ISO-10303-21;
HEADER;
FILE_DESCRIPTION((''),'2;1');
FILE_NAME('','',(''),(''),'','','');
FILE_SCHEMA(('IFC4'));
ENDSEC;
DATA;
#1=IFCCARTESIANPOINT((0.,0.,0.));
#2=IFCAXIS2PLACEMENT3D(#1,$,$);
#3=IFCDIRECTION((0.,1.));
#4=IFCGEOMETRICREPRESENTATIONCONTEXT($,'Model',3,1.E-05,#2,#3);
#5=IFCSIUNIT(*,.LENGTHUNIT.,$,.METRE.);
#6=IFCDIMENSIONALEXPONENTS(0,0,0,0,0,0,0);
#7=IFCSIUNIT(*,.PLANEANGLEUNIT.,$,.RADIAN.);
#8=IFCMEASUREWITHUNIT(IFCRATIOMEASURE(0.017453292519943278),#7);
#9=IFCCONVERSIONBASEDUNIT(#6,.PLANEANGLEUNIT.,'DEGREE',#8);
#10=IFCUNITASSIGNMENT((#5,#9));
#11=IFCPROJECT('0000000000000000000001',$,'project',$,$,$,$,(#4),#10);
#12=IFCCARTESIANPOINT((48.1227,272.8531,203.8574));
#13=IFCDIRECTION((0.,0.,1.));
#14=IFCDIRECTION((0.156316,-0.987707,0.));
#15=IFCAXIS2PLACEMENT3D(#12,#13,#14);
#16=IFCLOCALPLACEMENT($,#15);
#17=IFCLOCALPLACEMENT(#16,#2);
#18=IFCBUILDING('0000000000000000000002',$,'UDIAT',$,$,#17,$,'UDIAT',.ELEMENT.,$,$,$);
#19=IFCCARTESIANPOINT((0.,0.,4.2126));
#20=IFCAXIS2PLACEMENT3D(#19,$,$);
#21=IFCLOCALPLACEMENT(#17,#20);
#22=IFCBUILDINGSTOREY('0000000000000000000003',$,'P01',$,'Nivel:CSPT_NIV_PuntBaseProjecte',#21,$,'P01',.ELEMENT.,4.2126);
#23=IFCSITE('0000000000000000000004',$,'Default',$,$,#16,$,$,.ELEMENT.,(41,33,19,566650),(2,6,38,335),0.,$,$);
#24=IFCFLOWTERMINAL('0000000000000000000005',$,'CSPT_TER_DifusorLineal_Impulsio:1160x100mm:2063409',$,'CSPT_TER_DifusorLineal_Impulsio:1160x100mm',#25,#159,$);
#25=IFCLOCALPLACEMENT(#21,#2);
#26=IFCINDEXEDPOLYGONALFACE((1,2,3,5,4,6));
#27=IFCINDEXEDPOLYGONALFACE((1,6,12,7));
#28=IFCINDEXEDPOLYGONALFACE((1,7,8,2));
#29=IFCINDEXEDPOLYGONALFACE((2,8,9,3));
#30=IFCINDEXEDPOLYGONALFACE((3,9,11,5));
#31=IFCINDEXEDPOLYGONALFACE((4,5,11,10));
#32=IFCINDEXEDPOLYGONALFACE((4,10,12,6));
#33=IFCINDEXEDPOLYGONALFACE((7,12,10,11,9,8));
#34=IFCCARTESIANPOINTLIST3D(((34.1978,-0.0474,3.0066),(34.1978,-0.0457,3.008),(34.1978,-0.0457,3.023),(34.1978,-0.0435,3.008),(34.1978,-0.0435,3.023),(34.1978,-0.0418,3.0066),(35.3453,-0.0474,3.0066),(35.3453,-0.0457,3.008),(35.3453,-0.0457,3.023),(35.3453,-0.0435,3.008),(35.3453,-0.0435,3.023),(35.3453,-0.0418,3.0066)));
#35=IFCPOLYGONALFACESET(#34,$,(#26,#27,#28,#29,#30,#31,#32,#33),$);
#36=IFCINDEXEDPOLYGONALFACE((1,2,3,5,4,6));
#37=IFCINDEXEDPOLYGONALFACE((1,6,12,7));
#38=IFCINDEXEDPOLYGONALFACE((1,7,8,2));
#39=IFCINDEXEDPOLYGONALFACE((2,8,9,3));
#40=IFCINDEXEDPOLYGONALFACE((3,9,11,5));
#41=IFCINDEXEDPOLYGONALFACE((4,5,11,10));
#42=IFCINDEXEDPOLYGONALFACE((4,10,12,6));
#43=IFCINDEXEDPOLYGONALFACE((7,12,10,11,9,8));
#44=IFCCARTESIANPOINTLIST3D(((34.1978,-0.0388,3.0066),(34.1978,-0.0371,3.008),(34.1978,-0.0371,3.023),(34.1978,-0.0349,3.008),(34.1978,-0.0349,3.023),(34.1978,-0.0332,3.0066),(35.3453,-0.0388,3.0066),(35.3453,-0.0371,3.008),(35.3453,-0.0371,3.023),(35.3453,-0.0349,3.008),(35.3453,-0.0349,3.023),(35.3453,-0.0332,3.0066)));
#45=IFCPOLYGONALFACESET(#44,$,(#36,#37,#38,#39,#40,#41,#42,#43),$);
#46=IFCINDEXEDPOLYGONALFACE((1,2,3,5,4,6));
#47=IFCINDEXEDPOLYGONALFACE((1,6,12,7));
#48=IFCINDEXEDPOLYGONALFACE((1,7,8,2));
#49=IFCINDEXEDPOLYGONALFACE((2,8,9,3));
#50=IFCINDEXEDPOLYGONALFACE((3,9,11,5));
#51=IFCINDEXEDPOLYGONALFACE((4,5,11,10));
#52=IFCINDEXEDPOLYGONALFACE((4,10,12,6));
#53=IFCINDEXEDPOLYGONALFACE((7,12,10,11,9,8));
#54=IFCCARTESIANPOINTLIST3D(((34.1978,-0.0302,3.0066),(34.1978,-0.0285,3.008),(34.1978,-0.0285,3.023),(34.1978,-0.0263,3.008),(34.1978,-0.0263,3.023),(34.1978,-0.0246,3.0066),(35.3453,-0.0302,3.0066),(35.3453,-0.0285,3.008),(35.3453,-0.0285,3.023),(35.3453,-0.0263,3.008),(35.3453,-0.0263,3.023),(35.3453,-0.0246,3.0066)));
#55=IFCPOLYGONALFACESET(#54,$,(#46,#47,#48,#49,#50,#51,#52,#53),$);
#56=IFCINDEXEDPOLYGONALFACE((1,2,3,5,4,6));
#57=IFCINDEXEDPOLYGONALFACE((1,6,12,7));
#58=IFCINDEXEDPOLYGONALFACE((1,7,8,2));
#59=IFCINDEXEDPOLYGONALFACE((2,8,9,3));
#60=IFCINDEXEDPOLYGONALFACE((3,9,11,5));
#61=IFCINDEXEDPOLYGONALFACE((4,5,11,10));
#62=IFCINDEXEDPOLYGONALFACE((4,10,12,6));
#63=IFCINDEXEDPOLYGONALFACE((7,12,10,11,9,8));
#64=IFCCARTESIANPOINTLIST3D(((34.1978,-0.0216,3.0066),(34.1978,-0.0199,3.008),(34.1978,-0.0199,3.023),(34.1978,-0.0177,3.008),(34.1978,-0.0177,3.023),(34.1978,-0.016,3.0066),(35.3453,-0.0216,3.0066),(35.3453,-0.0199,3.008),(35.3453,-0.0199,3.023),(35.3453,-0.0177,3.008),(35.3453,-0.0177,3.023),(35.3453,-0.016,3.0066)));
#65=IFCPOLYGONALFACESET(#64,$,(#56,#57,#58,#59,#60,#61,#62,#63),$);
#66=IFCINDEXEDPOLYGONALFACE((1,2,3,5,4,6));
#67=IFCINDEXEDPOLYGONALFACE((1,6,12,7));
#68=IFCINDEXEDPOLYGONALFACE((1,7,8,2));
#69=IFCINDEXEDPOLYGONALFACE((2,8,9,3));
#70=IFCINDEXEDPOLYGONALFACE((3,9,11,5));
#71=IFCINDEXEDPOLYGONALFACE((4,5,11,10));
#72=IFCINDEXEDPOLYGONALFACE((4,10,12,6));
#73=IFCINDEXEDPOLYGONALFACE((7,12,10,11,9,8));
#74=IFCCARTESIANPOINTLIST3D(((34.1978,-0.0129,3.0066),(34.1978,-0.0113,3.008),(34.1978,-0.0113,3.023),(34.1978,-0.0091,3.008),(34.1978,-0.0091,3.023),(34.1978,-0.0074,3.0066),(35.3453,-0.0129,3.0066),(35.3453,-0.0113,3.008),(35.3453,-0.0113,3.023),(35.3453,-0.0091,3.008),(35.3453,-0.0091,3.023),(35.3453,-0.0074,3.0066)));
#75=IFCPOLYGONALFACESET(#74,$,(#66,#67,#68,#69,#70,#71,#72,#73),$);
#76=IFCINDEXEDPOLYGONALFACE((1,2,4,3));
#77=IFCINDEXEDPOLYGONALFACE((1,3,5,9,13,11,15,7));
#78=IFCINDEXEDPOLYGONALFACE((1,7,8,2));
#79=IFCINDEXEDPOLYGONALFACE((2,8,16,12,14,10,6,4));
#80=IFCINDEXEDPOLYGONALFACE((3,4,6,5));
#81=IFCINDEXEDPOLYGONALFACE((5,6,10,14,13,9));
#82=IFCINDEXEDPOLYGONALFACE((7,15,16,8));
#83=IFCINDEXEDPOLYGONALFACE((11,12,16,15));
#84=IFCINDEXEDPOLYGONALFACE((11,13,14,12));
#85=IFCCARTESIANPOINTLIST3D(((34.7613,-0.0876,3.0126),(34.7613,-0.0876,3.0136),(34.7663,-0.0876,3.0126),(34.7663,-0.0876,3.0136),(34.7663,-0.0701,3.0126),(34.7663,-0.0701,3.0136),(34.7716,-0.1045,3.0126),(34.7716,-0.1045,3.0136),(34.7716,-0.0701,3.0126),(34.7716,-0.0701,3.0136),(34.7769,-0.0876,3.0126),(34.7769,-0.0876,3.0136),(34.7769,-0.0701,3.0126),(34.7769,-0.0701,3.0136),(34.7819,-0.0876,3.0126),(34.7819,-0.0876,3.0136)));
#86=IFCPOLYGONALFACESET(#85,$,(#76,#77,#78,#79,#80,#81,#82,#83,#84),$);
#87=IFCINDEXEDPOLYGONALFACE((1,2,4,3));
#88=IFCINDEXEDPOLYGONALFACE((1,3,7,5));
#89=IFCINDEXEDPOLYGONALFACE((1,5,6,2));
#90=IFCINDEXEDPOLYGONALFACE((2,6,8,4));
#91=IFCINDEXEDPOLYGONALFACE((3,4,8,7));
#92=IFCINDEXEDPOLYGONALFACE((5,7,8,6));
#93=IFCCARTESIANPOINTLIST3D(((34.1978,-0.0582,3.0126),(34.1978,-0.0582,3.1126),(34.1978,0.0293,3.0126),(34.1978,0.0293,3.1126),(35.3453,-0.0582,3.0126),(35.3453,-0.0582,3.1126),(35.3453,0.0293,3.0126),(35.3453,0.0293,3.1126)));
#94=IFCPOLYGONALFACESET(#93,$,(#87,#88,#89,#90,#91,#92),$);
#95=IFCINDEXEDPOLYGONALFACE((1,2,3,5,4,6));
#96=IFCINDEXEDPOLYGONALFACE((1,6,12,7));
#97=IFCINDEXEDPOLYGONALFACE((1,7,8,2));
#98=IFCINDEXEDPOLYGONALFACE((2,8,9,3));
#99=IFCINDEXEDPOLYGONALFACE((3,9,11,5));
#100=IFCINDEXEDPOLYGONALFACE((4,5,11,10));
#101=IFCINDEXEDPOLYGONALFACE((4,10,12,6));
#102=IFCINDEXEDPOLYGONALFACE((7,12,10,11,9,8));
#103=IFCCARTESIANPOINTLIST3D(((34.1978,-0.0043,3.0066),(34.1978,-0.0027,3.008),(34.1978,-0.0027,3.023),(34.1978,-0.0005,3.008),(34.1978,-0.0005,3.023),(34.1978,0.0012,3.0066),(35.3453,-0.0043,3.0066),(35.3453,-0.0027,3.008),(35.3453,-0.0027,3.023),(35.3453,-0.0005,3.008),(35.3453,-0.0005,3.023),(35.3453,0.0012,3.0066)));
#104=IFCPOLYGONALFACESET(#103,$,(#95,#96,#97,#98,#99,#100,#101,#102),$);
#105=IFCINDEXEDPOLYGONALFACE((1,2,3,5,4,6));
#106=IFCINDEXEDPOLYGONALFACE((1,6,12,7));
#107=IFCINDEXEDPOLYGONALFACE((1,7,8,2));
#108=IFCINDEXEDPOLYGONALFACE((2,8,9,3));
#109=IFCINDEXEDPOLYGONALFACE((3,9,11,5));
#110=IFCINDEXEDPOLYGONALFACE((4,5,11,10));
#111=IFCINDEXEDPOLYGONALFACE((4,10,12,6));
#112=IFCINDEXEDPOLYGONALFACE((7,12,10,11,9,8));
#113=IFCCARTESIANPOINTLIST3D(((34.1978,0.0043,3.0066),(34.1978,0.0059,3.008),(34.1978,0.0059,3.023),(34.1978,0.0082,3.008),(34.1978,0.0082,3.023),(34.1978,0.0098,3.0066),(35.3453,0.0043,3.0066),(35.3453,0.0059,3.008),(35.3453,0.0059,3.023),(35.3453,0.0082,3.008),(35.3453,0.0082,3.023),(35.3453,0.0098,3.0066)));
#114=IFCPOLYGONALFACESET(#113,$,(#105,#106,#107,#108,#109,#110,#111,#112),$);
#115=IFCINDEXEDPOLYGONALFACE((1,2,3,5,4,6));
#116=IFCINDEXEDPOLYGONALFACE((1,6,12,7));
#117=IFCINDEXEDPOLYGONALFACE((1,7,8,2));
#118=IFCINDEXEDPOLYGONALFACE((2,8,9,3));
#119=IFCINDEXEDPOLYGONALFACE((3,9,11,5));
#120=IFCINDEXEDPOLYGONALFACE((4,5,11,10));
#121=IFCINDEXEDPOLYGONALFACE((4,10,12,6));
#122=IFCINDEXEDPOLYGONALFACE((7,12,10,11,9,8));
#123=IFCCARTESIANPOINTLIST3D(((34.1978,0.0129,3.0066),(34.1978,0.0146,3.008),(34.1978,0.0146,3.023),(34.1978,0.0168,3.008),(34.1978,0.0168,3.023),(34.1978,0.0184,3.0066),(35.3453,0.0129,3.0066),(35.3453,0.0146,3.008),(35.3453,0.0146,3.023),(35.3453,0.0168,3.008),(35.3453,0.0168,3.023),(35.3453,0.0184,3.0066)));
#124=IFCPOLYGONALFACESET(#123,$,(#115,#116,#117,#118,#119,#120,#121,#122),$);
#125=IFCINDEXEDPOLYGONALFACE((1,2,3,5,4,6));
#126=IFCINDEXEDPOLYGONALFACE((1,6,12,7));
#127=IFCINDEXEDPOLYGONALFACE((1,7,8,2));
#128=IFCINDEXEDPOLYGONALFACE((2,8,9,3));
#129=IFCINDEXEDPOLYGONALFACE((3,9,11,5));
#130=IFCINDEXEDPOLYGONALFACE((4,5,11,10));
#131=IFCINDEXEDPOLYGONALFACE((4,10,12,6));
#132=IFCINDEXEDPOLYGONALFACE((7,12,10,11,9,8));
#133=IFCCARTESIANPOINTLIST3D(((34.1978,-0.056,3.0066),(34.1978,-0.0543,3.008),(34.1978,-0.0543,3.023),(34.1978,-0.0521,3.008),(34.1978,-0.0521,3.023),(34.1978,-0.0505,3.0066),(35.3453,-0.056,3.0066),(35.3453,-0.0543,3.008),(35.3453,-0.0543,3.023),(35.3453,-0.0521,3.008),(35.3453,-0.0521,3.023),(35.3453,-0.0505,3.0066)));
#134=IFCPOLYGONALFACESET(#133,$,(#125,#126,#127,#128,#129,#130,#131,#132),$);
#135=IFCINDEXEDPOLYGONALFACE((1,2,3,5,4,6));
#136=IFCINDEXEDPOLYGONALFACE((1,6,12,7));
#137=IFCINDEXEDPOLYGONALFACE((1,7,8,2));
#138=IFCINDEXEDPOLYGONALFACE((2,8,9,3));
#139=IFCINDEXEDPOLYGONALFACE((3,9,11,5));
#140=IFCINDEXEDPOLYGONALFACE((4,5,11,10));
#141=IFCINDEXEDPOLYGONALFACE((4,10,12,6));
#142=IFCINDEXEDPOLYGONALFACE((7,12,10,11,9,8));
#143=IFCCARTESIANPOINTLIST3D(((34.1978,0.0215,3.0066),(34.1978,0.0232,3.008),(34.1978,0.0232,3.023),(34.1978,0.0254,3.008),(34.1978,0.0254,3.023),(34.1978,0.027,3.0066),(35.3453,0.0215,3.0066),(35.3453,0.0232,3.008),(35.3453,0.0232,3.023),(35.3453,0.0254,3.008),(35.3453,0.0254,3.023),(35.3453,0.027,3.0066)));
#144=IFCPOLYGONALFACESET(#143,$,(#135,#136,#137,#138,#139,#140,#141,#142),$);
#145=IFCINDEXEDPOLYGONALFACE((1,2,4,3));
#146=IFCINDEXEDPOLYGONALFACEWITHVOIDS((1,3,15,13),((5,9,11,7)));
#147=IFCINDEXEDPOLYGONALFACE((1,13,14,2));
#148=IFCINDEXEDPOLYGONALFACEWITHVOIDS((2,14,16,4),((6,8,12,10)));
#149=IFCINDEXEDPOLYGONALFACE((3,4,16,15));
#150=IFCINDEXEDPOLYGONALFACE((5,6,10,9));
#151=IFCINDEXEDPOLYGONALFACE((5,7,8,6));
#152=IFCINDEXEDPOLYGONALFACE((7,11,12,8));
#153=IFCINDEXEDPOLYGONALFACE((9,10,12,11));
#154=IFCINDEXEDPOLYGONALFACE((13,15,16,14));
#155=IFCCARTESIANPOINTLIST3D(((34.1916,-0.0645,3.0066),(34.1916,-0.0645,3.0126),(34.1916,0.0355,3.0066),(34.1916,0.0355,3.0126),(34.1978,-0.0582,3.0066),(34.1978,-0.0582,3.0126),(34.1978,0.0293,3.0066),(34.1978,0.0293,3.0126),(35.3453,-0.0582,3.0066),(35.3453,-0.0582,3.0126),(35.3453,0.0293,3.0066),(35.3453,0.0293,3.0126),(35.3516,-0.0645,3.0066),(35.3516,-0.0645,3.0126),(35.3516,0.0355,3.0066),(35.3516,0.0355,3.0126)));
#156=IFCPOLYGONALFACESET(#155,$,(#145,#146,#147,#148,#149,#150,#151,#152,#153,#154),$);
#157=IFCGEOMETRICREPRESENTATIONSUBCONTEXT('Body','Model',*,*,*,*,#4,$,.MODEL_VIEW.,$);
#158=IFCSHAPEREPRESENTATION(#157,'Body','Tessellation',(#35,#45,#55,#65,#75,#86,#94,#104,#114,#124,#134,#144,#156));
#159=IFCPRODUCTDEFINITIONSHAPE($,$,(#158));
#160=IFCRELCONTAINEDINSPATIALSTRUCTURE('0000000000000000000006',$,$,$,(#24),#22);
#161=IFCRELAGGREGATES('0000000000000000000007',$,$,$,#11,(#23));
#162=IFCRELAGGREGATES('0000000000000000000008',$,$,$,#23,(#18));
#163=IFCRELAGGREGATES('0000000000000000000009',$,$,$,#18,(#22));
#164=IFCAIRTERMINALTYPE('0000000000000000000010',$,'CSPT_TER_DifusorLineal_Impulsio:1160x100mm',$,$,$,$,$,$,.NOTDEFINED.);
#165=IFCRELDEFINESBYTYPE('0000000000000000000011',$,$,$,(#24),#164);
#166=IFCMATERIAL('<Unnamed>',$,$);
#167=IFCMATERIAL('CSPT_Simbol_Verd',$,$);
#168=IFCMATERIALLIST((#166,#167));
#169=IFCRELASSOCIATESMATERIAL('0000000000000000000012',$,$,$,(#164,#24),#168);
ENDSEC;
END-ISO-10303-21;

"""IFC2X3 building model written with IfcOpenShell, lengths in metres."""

from ifc_helpers import new_model, entity, si_unit, converted_unit, direction, frame, origin, origin_2d_with_axis, place, context, subcontext, project, spatial, polyline, rectangle, outline, extrude, source, transform, mapped, material, material_list, type_object, type_shapes, element, save


model = new_model("IFC2X3")

# Units and contexts
model_context = context("Model", 3, precision=1e-05, world=origin(), true_north=direction((0.0, 1.0)))
body_context = subcontext(model_context, "Body", "Model", "MODEL_VIEW")
ifc_project = project(units=[si_unit("LENGTHUNIT", "METRE"), converted_unit("PLANEANGLEUNIT", "DEGREE", entity("IfcRatioMeasure", 0.017453292519943278), si_unit("PLANEANGLEUNIT", "RADIAN"), dimensions=[0, 0, 0, 0, 0, 0, 0])], contexts=[model_context])

# Site, building, storey
site_placement = place(None, frame((48.1227, 272.8531, 203.8574), z_axis=(0.0, 0.0, 1.0), x_axis=(0.156316, -0.987707, 0.0)))
site = spatial("IfcSite", under=ifc_project, at=site_placement, Name="Default", CompositionType="ELEMENT", RefLatitude=(41, 33, 19, 566650), RefLongitude=(2, 6, 38, 335), RefElevation=0.0)
building_placement = place(site_placement, origin())
building = spatial("IfcBuilding", under=site, at=building_placement, Name="UDIAT", LongName="UDIAT", CompositionType="ELEMENT")
storey_placement = place(building_placement, frame((0.0, 0.0, 4.2126)))
storey = spatial("IfcBuildingStorey", under=building, at=storey_placement, Name="P01", ObjectType="Nivel:CSPT_NIV_PuntBaseProjecte", LongName="P01", CompositionType="ELEMENT", Elevation=4.2126)

# Shared definitions
ifc_material_1 = material(Name="<Unnamed>")

# Flow terminal
ifc_material_2 = material(Name="CSPT_Simbol_Verd")
ifc_material_list = material_list([ifc_material_1, ifc_material_2])
air_terminal_type = type_object("IfcAirTerminalType", Name="CSPT_TER_DifusorLineal_Impulsio:1160x100mm", PredefinedType="NOTDEFINED", material=ifc_material_list)
shared_shape_1 = source(origin(), body_context, "Body", "SweptSolid", [
    extrude(outline(polyline([(0.0037, 0.0028), (0.0059, 0.0028), (0.0016, 0.0063), (0.002, 0.0042), (-0.0074, -0.0074), (-0.0057, -0.0088), (0.0037, 0.0028)])), frame((-0.5737, 0.0301, -0.0001), z_axis=(1.0, 0.0, 0.0), x_axis=(0.0, -0.776119, -0.630587)), (0.0, 0.0, 1.0), 1.1475),
    extrude(outline(polyline([(0.0037, 0.0028), (0.0059, 0.0028), (0.0016, 0.0063), (0.002, 0.0042), (-0.0074, -0.0074), (-0.0057, -0.0088), (0.0037, 0.0028)])), frame((-0.5737, 0.0215, -0.0001), z_axis=(1.0, 0.0, 0.0), x_axis=(0.0, -0.776119, -0.630587)), (0.0, 0.0, 1.0), 1.1475),
    extrude(outline(polyline([(0.0037, 0.0028), (0.0059, 0.0028), (0.0016, 0.0063), (0.002, 0.0042), (-0.0074, -0.0074), (-0.0057, -0.0088), (0.0037, 0.0028)])), frame((-0.5737, 0.0129, -0.0001), z_axis=(1.0, 0.0, 0.0), x_axis=(0.0, -0.776119, -0.630587)), (0.0, 0.0, 1.0), 1.1475),
    extrude(outline(polyline([(0.0037, 0.0028), (0.0059, 0.0028), (0.0016, 0.0063), (0.002, 0.0042), (-0.0074, -0.0074), (-0.0057, -0.0088), (0.0037, 0.0028)])), frame((-0.5737, 0.0043, -0.0001), z_axis=(1.0, 0.0, 0.0), x_axis=(0.0, -0.776119, -0.630587)), (0.0, 0.0, 1.0), 1.1475),
    extrude(outline(polyline([(0.0037, 0.0028), (0.0059, 0.0028), (0.0016, 0.0063), (0.002, 0.0042), (-0.0074, -0.0074), (-0.0057, -0.0088), (0.0037, 0.0028)])), frame((-0.5737, -0.0043, -0.0001), z_axis=(1.0, 0.0, 0.0), x_axis=(0.0, -0.776119, -0.630587)), (0.0, 0.0, 1.0), 1.1475),
    extrude(outline(polyline([(0.0, -0.013), (0.0053, -0.013), (0.0053, 0.0045), (0.0103, 0.0045), (0.0, 0.0213), (-0.0103, 0.0045), (-0.0053, 0.0045), (-0.0053, -0.013), (0.0, -0.013)])), frame((0.0, 0.0687, 0.0)), (0.0, 0.0, 1.0), 0.001),
    extrude(rectangle(XDim=1.1475, YDim=0.0875, at=origin_2d_with_axis()), frame((0.0, 0.0, 0.0), z_axis=(0.0, 0.0, 1.0), x_axis=(-1.0, 0.0, 0.0)), (0.0, 0.0, 1.0), 0.1),
    extrude(outline(polyline([(0.0037, 0.0028), (0.0059, 0.0028), (0.0016, 0.0063), (0.002, 0.0042), (-0.0074, -0.0074), (-0.0057, -0.0088), (0.0037, 0.0028)])), frame((-0.5737, -0.0129, -0.0001), z_axis=(1.0, 0.0, 0.0), x_axis=(0.0, -0.776119, -0.630587)), (0.0, 0.0, 1.0), 1.1475),
    extrude(outline(polyline([(0.0037, 0.0028), (0.0059, 0.0028), (0.0016, 0.0063), (0.002, 0.0042), (-0.0074, -0.0074), (-0.0057, -0.0088), (0.0037, 0.0028)])), frame((-0.5737, -0.0215, -0.0001), z_axis=(1.0, 0.0, 0.0), x_axis=(0.0, -0.776119, -0.630587)), (0.0, 0.0, 1.0), 1.1475),
    extrude(outline(polyline([(0.0037, 0.0028), (0.0059, 0.0028), (0.0016, 0.0063), (0.002, 0.0042), (-0.0074, -0.0074), (-0.0057, -0.0088), (0.0037, 0.0028)])), frame((-0.5737, -0.0301, -0.0001), z_axis=(1.0, 0.0, 0.0), x_axis=(0.0, -0.776119, -0.630587)), (0.0, 0.0, 1.0), 1.1475),
    extrude(outline(polyline([(0.0037, 0.0028), (0.0059, 0.0028), (0.0016, 0.0063), (0.002, 0.0042), (-0.0074, -0.0074), (-0.0057, -0.0088), (0.0037, 0.0028)])), frame((-0.5737, 0.0388, -0.0001), z_axis=(1.0, 0.0, 0.0), x_axis=(0.0, -0.776119, -0.630587)), (0.0, 0.0, 1.0), 1.1475),
    extrude(outline(polyline([(0.0037, 0.0028), (0.0059, 0.0028), (0.0016, 0.0063), (0.002, 0.0042), (-0.0074, -0.0074), (-0.0057, -0.0088), (0.0037, 0.0028)])), frame((-0.5737, -0.0387, -0.0001), z_axis=(1.0, 0.0, 0.0), x_axis=(0.0, -0.776119, -0.630587)), (0.0, 0.0, 1.0), 1.1475),
    extrude(outline(polyline([(-0.58, -0.05), (0.58, -0.05), (0.58, 0.05), (-0.58, 0.05), (-0.58, -0.05)]), holes=[polyline([(-0.5738, -0.0438), (-0.5738, 0.0437), (0.5737, 0.0437), (0.5737, -0.0438), (-0.5738, -0.0438)])]), frame((0.0, 0.0, -0.006), z_axis=(0.0, 0.0, 1.0), x_axis=(-1.0, 0.0, 0.0)), (0.0, 0.0, 1.0), 0.006),
])
type_shapes(air_terminal_type, [shared_shape_1])
for number, where, z_axis, x_axis, name in (
    (1, (34.7716, -0.0145, 3.0126), (0.0, 0.0, 1.0), (-1.0, 0.0, 0.0), "CSPT_TER_DifusorLineal_Impulsio:1160x100mm:2063409"),
):
    element("IfcFlowTerminal", number, at=place(storey_placement, frame(where, z_axis=z_axis, x_axis=x_axis)), inside=storey, type_object=air_terminal_type, material=ifc_material_list, Name=name, ObjectType="CSPT_TER_DifusorLineal_Impulsio:1160x100mm", context=body_context, shape_type="MappedRepresentation", body=[
        mapped(shared_shape_1, transform((0.0, 0.0, 0.0), scale=1.0)),
    ])

save(model, "model.ifc")
